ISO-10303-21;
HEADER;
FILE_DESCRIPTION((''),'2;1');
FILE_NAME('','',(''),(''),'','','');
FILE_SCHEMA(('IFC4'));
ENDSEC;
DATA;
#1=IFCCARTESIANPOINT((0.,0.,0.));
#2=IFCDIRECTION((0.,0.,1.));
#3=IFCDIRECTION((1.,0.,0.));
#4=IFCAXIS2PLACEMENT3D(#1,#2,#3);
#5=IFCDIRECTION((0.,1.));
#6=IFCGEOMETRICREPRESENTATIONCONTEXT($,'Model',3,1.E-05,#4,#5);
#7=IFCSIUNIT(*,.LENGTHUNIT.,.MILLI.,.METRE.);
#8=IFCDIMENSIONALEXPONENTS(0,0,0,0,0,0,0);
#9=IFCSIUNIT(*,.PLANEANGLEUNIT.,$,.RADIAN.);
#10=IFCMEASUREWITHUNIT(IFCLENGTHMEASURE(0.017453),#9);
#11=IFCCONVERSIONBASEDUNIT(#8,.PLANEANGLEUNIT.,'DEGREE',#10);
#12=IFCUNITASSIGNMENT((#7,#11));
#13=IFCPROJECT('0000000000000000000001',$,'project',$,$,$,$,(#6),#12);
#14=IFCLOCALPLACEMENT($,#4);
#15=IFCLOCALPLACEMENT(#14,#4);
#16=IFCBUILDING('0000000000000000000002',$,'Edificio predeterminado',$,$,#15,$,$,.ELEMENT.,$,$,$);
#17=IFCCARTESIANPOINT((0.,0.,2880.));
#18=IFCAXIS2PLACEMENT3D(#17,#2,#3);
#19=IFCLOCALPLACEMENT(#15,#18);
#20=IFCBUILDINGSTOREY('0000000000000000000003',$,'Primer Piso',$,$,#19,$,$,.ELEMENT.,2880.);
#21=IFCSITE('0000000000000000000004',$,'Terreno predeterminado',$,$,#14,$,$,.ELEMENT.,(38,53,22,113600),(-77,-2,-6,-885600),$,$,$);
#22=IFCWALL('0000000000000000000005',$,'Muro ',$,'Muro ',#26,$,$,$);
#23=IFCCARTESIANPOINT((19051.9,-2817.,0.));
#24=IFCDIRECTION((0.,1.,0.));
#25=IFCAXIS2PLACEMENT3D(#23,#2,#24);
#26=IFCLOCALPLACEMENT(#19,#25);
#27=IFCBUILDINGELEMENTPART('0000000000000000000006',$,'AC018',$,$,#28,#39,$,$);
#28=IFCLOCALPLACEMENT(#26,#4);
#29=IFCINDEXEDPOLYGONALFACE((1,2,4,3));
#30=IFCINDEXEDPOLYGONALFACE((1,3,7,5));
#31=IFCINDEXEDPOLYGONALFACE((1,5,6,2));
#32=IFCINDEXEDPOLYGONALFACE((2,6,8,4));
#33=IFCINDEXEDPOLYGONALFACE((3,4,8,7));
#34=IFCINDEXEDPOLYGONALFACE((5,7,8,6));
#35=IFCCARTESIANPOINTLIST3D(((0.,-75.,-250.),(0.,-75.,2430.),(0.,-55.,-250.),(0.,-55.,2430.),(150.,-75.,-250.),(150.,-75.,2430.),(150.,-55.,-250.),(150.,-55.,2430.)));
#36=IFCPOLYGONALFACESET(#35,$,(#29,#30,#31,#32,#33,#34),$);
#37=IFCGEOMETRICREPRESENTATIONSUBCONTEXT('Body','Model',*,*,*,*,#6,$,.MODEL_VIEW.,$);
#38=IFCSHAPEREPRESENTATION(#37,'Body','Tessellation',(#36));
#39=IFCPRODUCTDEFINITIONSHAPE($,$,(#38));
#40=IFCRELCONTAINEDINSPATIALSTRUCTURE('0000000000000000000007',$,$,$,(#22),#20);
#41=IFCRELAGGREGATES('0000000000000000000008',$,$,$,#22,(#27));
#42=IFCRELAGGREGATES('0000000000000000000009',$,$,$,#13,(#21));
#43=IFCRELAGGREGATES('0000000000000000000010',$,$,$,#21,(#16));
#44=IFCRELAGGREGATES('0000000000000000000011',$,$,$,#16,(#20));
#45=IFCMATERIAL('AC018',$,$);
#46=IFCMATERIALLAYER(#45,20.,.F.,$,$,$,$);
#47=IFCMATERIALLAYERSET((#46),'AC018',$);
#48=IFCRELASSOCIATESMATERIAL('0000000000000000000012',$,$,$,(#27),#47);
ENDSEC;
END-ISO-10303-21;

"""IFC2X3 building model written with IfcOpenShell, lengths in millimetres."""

from ifc_helpers import new_model, entity, si_unit, converted_unit, direction, frame, origin_with_axes, place, context, subcontext, project, spatial, polyline, outline, extrude, clip, bounded_halfspace, material, layer, layer_set, layer_usage, element, aggregate, save


model = new_model("IFC2X3")

# Units and contexts
model_context = context("Model", 3, precision=1e-05, world=origin_with_axes(), true_north=direction((0.0, 1.0)))
body_context = subcontext(model_context, "Body", "Model", "MODEL_VIEW")
ifc_project = project(units=[si_unit("LENGTHUNIT", "METRE", prefix="MILLI"), converted_unit("PLANEANGLEUNIT", "DEGREE", entity("IfcLengthMeasure", 0.017453), si_unit("PLANEANGLEUNIT", "RADIAN"), dimensions=[0, 0, 0, 0, 0, 0, 0])], contexts=[model_context])

# Site, building, storey
site_placement = place(None, origin_with_axes())
site = spatial("IfcSite", under=ifc_project, at=site_placement, Name="Terreno predeterminado", CompositionType="ELEMENT", RefLatitude=(38, 53, 22, 113600), RefLongitude=(-77, -2, -6, -885600))
building_placement = place(site_placement, origin_with_axes())
building = spatial("IfcBuilding", under=site, at=building_placement, Name="Edificio predeterminado", CompositionType="ELEMENT")
storey_placement = place(building_placement, frame((0.0, 0.0, 2880.0), z_axis=(0.0, 0.0, 1.0), x_axis=(1.0, 0.0, 0.0)))
storey = spatial("IfcBuildingStorey", under=building, at=storey_placement, Name="Primer Piso", CompositionType="ELEMENT", Elevation=2880.0)

# Wall, building element part
wall_1_placement = place(storey_placement, frame((19051.9, -2817.0, 0.0), z_axis=(0.0, 0.0, 1.0), x_axis=(0.0, 1.0, 0.0)))
wall_1 = element("IfcWall", 1, at=wall_1_placement, inside=storey, Name="Muro ", ObjectType="Muro ")
ifc_material_1 = material(Name="AC018")
ifc_layer_1 = layer(ifc_material_1, 20.0, ventilated=False)
ifc_layer_set_1 = layer_set([ifc_layer_1], Name="AC018")
ifc_layer_usage_1 = layer_usage(ifc_layer_set_1, "AXIS2", "NEGATIVE", 55.0)
building_element_part_1_placement = place(wall_1_placement, origin_with_axes())
building_element_part_1 = element("IfcBuildingElementPart", 2, at=building_element_part_1_placement, material=ifc_layer_usage_1, Name="AC018", context=body_context, shape_type="Clipping", body=[
    clip(clip(extrude(outline(polyline([(150.0, -55.0), (150.0, -75.0), (0.0, -75.0), (0.0, -55.0), (150.0, -55.0)])), frame((0.0, 0.0, -250.0), z_axis=(0.0, 0.0, 1.0), x_axis=(1.0, 0.0, 0.0)), (0.0, 0.0, 1.0), 2680.0), bounded_halfspace(frame((0.0, 0.0, -250.0), z_axis=(0.0, 0.0, 1.0), x_axis=(1.0, 0.0, 0.0)), True, origin_with_axes(), polyline([(-150.0, -150.0), (375.0, -150.0), (375.0, 150.0), (-150.0, 150.0), (-150.0, -150.0)]))), bounded_halfspace(frame((0.0, 0.0, 2430.0), z_axis=(0.0, 0.0, 1.0), x_axis=(1.0, 0.0, 0.0)), False, origin_with_axes(), polyline([(-150.0, -150.0), (375.0, -150.0), (375.0, 150.0), (-150.0, 150.0), (-150.0, -150.0)]))),
])
aggregate(wall_1, [building_element_part_1])

save(model, "model.ifc")
